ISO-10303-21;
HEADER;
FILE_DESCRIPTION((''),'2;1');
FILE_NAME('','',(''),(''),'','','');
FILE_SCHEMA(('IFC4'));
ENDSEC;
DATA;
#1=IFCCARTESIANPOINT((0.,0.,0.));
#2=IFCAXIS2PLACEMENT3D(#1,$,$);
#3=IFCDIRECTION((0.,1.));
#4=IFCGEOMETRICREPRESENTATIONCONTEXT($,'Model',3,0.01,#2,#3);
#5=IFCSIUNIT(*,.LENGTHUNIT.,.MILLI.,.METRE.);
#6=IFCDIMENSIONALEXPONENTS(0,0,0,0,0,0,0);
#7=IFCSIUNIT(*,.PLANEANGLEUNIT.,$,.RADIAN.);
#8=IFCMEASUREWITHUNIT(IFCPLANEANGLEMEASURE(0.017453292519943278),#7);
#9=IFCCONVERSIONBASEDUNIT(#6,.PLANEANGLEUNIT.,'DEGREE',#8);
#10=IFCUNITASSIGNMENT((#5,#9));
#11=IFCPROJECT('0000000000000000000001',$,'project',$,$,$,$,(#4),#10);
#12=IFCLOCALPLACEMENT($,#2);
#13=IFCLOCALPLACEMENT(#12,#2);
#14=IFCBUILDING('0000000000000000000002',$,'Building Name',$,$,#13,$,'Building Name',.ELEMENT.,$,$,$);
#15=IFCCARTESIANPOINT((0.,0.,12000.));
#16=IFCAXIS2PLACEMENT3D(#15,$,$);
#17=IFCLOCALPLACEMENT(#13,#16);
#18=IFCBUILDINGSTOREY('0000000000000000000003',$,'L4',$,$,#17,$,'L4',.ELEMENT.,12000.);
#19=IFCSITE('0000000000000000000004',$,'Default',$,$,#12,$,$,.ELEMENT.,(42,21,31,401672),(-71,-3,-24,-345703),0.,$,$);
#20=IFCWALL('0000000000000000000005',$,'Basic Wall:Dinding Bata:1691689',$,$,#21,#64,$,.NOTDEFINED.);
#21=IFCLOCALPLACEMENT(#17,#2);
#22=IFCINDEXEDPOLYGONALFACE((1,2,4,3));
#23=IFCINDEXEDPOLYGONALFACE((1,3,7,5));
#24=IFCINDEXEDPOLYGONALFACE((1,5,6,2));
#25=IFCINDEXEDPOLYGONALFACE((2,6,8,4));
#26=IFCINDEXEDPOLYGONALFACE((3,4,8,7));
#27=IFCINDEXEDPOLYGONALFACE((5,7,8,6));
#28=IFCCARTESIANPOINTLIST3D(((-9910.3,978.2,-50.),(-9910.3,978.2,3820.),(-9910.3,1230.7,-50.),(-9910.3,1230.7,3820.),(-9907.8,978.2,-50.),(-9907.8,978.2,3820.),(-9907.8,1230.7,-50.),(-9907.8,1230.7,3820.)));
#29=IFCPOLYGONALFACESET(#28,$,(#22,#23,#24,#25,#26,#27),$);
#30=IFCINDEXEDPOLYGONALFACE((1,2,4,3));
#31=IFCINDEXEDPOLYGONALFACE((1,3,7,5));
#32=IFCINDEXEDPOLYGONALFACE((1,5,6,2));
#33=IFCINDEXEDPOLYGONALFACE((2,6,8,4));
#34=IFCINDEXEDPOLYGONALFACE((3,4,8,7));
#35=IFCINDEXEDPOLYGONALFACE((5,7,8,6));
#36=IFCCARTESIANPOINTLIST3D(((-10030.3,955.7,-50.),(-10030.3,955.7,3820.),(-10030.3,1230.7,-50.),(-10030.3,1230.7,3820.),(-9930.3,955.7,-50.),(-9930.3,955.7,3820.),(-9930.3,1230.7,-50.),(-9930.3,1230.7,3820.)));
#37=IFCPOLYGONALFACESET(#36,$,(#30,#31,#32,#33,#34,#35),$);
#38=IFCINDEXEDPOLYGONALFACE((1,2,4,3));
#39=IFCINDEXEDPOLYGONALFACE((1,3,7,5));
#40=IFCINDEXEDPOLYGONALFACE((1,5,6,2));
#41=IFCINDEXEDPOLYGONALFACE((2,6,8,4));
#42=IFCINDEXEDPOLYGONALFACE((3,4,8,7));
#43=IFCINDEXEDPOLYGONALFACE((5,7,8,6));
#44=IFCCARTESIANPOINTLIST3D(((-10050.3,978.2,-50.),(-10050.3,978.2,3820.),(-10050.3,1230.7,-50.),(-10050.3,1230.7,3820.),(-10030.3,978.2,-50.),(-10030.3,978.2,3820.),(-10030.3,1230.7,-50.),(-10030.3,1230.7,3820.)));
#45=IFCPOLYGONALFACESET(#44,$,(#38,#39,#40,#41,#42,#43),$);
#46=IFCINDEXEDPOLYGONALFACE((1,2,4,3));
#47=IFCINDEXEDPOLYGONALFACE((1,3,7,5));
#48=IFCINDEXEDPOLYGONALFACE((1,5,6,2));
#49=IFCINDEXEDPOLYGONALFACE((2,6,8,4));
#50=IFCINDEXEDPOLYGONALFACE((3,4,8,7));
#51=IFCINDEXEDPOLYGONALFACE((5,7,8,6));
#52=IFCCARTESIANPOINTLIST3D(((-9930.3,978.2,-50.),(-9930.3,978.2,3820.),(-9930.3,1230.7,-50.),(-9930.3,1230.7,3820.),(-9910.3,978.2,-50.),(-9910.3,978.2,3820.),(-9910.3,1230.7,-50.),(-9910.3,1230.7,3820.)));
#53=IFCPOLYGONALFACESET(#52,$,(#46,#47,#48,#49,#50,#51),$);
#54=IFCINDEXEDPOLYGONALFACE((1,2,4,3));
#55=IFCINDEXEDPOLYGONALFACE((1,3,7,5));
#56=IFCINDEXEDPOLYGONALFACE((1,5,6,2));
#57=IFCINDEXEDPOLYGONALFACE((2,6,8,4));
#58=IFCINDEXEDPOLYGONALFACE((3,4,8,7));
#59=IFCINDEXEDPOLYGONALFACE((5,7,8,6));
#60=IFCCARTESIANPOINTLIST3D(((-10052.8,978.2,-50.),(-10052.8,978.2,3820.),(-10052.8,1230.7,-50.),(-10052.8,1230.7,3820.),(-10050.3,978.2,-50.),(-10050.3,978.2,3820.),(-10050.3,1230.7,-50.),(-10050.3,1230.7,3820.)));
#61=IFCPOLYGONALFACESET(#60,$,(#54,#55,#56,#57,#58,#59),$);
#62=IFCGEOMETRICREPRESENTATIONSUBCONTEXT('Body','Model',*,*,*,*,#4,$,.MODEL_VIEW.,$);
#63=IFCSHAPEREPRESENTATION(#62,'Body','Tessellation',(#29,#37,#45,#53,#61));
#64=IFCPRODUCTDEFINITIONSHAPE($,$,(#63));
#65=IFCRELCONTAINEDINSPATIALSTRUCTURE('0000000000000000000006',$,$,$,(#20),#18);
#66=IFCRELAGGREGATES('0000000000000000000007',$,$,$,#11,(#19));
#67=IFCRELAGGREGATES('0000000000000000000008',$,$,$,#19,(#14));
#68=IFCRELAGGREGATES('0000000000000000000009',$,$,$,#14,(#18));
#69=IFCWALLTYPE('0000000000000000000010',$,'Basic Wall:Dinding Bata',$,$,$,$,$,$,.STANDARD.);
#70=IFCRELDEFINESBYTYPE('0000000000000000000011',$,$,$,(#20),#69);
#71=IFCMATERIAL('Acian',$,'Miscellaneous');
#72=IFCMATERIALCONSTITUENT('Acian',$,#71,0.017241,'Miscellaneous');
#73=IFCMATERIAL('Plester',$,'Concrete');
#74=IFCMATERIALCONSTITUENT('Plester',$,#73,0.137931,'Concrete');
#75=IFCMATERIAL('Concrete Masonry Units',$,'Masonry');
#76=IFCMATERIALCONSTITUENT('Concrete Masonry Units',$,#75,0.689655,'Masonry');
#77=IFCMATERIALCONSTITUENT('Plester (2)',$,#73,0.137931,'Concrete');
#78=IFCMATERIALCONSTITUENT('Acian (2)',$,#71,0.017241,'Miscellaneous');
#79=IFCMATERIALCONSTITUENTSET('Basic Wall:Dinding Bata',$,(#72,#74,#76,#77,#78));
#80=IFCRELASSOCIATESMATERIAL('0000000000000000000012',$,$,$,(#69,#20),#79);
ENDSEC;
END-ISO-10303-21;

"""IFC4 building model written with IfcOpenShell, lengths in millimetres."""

from ifc_helpers import new_model, entity, si_unit, converted_unit, direction, frame, origin, place, context, subcontext, project, spatial, indexed_curve, outline, extrude, material, constituent, constituent_set, type_object, element, save


model = new_model("IFC4")

# Units and contexts
model_context = context("Model", 3, precision=0.01, world=origin(), true_north=direction((0.0, 1.0)))
body_context = subcontext(model_context, "Body", "Model", "MODEL_VIEW")
ifc_project = project(units=[si_unit("LENGTHUNIT", "METRE", prefix="MILLI"), converted_unit("PLANEANGLEUNIT", "DEGREE", entity("IfcPlaneAngleMeasure", 0.017453292519943278), si_unit("PLANEANGLEUNIT", "RADIAN"), dimensions=[0, 0, 0, 0, 0, 0, 0])], contexts=[model_context])

# Site, building, storey
site_placement = place(None, origin())
site = spatial("IfcSite", under=ifc_project, at=site_placement, Name="Default", CompositionType="ELEMENT", RefLatitude=(42, 21, 31, 401672), RefLongitude=(-71, -3, -24, -345703), RefElevation=0.0)
building_placement = place(site_placement, origin())
building = spatial("IfcBuilding", under=site, at=building_placement, Name="Building Name", LongName="Building Name", CompositionType="ELEMENT")
storey_placement = place(building_placement, frame((0.0, 0.0, 12000.0)))
storey = spatial("IfcBuildingStorey", under=building, at=storey_placement, Name="L4", LongName="L4", CompositionType="ELEMENT", Elevation=12000.0)

# Wall
ifc_material_1 = material(Name="Acian", Category="Miscellaneous")
ifc_constituent_1 = constituent(ifc_material_1, Name="Acian", Category="Miscellaneous", fraction=0.017241)
ifc_material_2 = material(Name="Plester", Category="Concrete")
ifc_constituent_2 = constituent(ifc_material_2, Name="Plester", Category="Concrete", fraction=0.137931)
ifc_material_3 = material(Name="Concrete Masonry Units", Category="Masonry")
ifc_constituent_3 = constituent(ifc_material_3, Name="Concrete Masonry Units", Category="Masonry", fraction=0.689655)
ifc_constituent_4 = constituent(ifc_material_2, Name="Plester (2)", Category="Concrete", fraction=0.137931)
ifc_constituent_5 = constituent(ifc_material_1, Name="Acian (2)", Category="Miscellaneous", fraction=0.017241)
ifc_constituent_set = constituent_set(constituents=[ifc_constituent_1, ifc_constituent_2, ifc_constituent_3, ifc_constituent_4, ifc_constituent_5], Name="Basic Wall:Dinding Bata")
wall_type = type_object("IfcWallType", Name="Basic Wall:Dinding Bata", PredefinedType="STANDARD", material=ifc_constituent_set)
wall_1_placement = place(storey_placement, frame((-9980.3, 1230.7, -50.0), z_axis=(0.0, 0.0, 1.0), x_axis=(0.0, -1.0, 0.0)))
element("IfcWall", 1, at=wall_1_placement, inside=storey, type_object=wall_type, material=ifc_constituent_set, Name="Basic Wall:Dinding Bata:1691689", PredefinedType="NOTDEFINED", context=body_context, shape_type="SweptSolid", body=[
    extrude(outline(indexed_curve([(-1.2, -126.2), (1.3, -126.2), (1.3, 126.2), (-1.2, 126.2), (-1.2, -126.2)], self_intersect=False)), frame((126.2, 71.3, 0.0), z_axis=(0.0, 0.0, 1.0), x_axis=(0.0, -1.0, 0.0)), (0.0, 0.0, 1.0), 3870.0),
    extrude(outline(indexed_curve([(-137.5, -50.0), (137.5, -50.0), (137.5, 50.0), (-137.5, 50.0), (-137.5, -50.0)], self_intersect=False)), frame((137.5, 0.0, 0.0)), (0.0, 0.0, 1.0), 3870.0),
    extrude(outline(indexed_curve([(-126.2, -10.0), (126.2, -10.0), (126.2, 10.0), (-126.2, 10.0), (-126.2, -10.0)], self_intersect=False)), frame((126.2, -60.0, 0.0)), (0.0, 0.0, 1.0), 3870.0),
    extrude(outline(indexed_curve([(-126.2, -10.0), (126.2, -10.0), (126.2, 10.0), (-126.2, 10.0), (-126.2, -10.0)], self_intersect=False)), frame((126.2, 60.0, 0.0)), (0.0, 0.0, 1.0), 3870.0),
    extrude(outline(indexed_curve([(-1.2, -126.2), (1.2, -126.2), (1.2, 126.2), (-1.2, 126.2), (-1.2, -126.2)], self_intersect=False)), frame((126.2, -71.2, 0.0), z_axis=(0.0, 0.0, 1.0), x_axis=(0.0, 1.0, 0.0)), (0.0, 0.0, 1.0), 3870.0),
])

save(model, "model.ifc")
